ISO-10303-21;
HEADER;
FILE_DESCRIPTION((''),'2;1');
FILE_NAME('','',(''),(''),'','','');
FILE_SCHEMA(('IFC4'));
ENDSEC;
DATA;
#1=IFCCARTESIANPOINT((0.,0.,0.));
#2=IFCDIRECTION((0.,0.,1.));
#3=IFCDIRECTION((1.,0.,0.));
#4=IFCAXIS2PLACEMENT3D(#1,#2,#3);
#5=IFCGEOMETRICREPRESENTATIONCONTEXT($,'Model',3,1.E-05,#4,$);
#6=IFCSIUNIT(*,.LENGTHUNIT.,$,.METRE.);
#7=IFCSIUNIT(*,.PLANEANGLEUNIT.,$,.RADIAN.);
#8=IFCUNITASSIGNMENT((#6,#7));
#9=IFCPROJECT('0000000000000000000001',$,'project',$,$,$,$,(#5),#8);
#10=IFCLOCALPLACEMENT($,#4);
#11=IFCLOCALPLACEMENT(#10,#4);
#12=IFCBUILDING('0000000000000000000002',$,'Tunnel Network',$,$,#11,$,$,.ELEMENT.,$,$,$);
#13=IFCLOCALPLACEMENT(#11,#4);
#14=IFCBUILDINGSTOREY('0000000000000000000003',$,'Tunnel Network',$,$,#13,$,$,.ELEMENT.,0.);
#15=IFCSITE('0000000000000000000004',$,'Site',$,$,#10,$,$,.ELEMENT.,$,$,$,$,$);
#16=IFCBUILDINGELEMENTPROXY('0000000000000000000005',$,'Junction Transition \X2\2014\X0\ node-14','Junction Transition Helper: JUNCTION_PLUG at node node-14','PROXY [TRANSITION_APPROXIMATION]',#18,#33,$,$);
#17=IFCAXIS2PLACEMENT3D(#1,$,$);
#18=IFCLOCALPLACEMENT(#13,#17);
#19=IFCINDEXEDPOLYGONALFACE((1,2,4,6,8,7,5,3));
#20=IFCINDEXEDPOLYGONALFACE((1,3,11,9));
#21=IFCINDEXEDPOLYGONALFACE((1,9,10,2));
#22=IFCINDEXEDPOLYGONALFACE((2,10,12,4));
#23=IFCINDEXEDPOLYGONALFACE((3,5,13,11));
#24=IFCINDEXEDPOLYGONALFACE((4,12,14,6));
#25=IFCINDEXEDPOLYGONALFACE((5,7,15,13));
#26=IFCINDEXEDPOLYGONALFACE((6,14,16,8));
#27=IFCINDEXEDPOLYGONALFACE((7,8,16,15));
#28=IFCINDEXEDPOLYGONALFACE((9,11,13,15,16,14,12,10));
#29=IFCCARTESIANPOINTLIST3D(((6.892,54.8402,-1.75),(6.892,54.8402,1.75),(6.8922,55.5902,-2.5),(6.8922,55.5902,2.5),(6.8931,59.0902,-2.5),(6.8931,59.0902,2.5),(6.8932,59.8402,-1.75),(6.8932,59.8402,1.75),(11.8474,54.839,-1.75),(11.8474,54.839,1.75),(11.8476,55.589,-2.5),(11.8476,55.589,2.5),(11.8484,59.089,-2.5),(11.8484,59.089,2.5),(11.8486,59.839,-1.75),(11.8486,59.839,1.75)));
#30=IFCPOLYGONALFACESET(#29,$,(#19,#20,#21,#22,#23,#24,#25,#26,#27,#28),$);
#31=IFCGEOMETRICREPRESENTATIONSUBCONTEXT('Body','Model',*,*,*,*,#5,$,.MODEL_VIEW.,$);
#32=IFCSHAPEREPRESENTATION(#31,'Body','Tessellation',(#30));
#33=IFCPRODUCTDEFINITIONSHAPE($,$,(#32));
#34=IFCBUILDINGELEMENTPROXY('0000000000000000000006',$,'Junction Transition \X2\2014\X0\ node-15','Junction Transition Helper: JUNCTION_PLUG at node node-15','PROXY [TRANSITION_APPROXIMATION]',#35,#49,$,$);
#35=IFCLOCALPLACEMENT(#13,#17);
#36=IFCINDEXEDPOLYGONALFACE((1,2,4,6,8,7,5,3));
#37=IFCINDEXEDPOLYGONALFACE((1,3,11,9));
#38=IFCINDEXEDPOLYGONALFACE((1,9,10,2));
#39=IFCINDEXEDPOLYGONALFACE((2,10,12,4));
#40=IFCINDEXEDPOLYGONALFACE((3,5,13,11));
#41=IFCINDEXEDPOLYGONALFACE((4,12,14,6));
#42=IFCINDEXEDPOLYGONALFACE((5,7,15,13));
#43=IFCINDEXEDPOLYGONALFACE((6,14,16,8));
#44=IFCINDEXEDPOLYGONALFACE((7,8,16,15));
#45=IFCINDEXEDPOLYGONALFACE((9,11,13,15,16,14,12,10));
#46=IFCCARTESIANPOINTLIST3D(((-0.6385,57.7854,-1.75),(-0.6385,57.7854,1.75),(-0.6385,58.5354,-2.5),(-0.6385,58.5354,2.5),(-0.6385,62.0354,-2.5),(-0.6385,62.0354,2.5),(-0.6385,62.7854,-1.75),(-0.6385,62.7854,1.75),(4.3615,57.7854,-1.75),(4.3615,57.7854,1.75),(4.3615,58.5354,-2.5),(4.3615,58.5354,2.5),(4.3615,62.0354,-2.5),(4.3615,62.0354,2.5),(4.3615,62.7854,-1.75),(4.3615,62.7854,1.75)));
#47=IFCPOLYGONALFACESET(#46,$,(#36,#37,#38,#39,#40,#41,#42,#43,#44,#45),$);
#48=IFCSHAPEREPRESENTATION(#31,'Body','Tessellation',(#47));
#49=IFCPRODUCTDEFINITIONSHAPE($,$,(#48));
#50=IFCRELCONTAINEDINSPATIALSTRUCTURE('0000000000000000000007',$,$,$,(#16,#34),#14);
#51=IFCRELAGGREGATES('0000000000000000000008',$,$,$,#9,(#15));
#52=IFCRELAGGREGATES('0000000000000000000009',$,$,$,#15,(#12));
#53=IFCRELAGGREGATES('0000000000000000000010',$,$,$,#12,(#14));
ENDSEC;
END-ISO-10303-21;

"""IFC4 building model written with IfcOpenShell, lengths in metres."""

from ifc_helpers import new_model, si_unit, frame, origin_with_axes, place, context, subcontext, project, spatial, polyline, outline, extrude, element, save


model = new_model("IFC4")

# Units and contexts
model_context = context("Model", 3, precision=1e-05, world=origin_with_axes())
body_context = subcontext(model_context, "Body", "Model", "MODEL_VIEW")
ifc_project = project(units=[si_unit("LENGTHUNIT", "METRE"), si_unit("PLANEANGLEUNIT", "RADIAN")], contexts=[model_context])

# Site, building, storey
site_placement = place(None, origin_with_axes())
site = spatial("IfcSite", under=ifc_project, at=site_placement, Name="Site", CompositionType="ELEMENT")
building_placement = place(site_placement, origin_with_axes())
building = spatial("IfcBuilding", under=site, at=building_placement, Name="Tunnel Network", CompositionType="ELEMENT")
storey_placement = place(building_placement, origin_with_axes())
storey = spatial("IfcBuildingStorey", under=building, at=storey_placement, Name="Tunnel Network", CompositionType="ELEMENT", Elevation=0.0)

# Building element proxies
proxy_1_placement = place(storey_placement, frame((11.848, 57.339, 0.0), z_axis=(-1.0, 0.00025, 0.0), x_axis=(0.00025, 1.0, 0.0)))
element("IfcBuildingElementProxy", 1, at=proxy_1_placement, inside=storey, Name="Junction Transition — node-14", Description="Junction Transition Helper: JUNCTION_PLUG at node node-14", ObjectType="PROXY [TRANSITION_APPROXIMATION]", context=body_context, shape_type="SweptSolid", body=[
    extrude(outline(polyline([(1.75, 2.5), (2.5, 1.75), (2.5, -1.75), (1.75, -2.5), (-1.75, -2.5), (-2.5, -1.75), (-2.5, 1.75), (-1.75, 2.5), (1.75, 2.5)])), origin_with_axes(), (0.0, 0.0, 1.0), 4.9554),
])
proxy_2_placement = place(storey_placement, frame((4.3615, 60.2854, 0.0), z_axis=(-1.0, 0.0, 0.0), x_axis=(0.0, 1.0, 0.0)))
element("IfcBuildingElementProxy", 2, at=proxy_2_placement, inside=storey, Name="Junction Transition — node-15", Description="Junction Transition Helper: JUNCTION_PLUG at node node-15", ObjectType="PROXY [TRANSITION_APPROXIMATION]", context=body_context, shape_type="SweptSolid", body=[
    extrude(outline(polyline([(1.75, 2.5), (2.5, 1.75), (2.5, -1.75), (1.75, -2.5), (-1.75, -2.5), (-2.5, -1.75), (-2.5, 1.75), (-1.75, 2.5), (1.75, 2.5)])), origin_with_axes(), (0.0, 0.0, 1.0), 5.0),
])

save(model, "model.ifc")
